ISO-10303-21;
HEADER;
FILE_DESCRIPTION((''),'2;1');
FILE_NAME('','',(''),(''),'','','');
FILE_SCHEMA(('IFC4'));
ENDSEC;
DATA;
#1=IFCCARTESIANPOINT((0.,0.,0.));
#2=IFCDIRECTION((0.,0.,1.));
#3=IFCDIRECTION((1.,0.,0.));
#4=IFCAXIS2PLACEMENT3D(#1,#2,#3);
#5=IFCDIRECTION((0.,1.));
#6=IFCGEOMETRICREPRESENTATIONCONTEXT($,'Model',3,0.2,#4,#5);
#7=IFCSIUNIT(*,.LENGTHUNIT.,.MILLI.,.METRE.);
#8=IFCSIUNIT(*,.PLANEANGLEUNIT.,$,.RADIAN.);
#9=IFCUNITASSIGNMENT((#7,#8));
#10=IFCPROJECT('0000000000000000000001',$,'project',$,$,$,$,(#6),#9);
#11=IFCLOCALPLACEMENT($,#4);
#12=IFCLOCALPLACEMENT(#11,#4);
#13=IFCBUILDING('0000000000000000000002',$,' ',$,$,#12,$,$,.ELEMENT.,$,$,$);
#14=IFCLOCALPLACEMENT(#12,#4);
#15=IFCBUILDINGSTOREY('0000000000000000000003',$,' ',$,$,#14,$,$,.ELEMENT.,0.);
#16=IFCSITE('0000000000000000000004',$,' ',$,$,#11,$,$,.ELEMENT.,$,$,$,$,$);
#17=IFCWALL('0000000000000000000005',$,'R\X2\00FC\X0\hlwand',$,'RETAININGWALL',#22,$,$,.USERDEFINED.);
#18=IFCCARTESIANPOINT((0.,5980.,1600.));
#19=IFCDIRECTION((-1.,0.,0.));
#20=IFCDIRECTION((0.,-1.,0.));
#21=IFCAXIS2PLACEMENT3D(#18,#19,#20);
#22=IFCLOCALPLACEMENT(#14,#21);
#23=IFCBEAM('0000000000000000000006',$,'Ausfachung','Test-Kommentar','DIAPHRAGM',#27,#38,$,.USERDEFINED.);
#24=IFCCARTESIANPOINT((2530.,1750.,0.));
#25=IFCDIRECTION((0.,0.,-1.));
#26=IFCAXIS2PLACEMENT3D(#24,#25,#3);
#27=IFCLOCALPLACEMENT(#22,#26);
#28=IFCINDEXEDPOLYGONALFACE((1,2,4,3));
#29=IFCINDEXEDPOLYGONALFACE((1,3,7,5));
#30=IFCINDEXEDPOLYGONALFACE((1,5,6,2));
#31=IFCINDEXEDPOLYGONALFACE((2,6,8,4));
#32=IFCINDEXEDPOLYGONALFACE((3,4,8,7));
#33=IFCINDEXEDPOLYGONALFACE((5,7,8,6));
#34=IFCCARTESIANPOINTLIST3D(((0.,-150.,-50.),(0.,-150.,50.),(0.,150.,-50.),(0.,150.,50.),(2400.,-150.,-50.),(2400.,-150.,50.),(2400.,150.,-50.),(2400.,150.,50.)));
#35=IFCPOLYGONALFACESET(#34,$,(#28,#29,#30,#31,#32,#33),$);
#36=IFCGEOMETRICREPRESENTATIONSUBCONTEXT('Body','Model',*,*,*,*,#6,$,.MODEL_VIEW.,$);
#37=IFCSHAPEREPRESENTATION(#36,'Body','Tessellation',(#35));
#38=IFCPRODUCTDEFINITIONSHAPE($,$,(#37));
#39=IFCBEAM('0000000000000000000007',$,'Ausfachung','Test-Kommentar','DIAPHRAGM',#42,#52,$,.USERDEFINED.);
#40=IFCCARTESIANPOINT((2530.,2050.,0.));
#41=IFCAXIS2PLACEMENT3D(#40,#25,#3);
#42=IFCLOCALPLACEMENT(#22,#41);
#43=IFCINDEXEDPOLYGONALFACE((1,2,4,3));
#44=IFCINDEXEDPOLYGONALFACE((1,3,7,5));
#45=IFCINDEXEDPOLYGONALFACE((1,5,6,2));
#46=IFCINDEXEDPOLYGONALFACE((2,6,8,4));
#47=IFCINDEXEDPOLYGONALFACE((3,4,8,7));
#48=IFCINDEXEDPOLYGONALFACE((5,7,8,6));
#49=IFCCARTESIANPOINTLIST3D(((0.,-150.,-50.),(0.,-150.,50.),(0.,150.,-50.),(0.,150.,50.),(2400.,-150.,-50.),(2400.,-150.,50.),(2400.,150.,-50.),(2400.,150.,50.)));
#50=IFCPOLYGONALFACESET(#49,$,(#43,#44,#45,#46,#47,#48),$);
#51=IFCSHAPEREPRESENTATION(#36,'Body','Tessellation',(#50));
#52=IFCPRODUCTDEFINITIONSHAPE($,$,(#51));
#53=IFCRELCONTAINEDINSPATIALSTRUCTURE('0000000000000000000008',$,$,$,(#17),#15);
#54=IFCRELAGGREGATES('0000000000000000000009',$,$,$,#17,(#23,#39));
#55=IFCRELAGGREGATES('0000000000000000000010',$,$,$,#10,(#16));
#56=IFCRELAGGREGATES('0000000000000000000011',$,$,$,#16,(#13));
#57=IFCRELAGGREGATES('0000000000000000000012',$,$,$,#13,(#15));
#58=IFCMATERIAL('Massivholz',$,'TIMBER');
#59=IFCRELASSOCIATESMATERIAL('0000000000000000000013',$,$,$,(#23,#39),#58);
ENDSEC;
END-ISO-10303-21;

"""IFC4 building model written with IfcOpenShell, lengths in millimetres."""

from ifc_helpers import new_model, si_unit, direction, frame, origin_with_axes, place, context, subcontext, project, spatial, line, indexed_curve, outline, extrude, material, element, aggregate, save


model = new_model("IFC4")

# Units and contexts
model_context = context("Model", 3, precision=0.2, world=origin_with_axes(), true_north=direction((0.0, 1.0)))
body_context = subcontext(model_context, "Body", "Model", "MODEL_VIEW")
ifc_project = project(units=[si_unit("LENGTHUNIT", "METRE", prefix="MILLI"), si_unit("PLANEANGLEUNIT", "RADIAN")], contexts=[model_context])

# Site, building, storey
site_placement = place(None, origin_with_axes())
site = spatial("IfcSite", under=ifc_project, at=site_placement, Name=" ", CompositionType="ELEMENT")
building_placement = place(site_placement, origin_with_axes())
building = spatial("IfcBuilding", under=site, at=building_placement, Name=" ", CompositionType="ELEMENT")
storey_placement = place(building_placement, origin_with_axes())
storey = spatial("IfcBuildingStorey", under=building, at=storey_placement, Name=" ", CompositionType="ELEMENT", Elevation=0.0)

# Wall, beams
wall_1_placement = place(storey_placement, frame((0.0, 5980.0, 1600.0), z_axis=(-1.0, 0.0, 0.0), x_axis=(0.0, -1.0, 0.0)))
wall_1 = element("IfcWall", 1, at=wall_1_placement, inside=storey, Name="Rühlwand", ObjectType="RETAININGWALL", PredefinedType="USERDEFINED")
ifc_material_1 = material(Name="Massivholz", Category="TIMBER")
beam_1_placement = place(wall_1_placement, frame((2530.0, 1750.0, 0.0), z_axis=(0.0, 0.0, -1.0), x_axis=(1.0, 0.0, 0.0)))
beam_1 = element("IfcBeam", 2, at=beam_1_placement, material=ifc_material_1, Name="Ausfachung", Description="Test-Kommentar", ObjectType="DIAPHRAGM", PredefinedType="USERDEFINED", context=body_context, shape_type="SolidModel", body=[
    extrude(outline(indexed_curve([(-50.0, -150.0), (50.0, -150.0), (50.0, 150.0), (-50.0, 150.0)], segments=[line(1, 2, 3, 4, 1)])), frame((0.0, 0.0, 0.0), z_axis=(-1.0, 0.0, 0.0), x_axis=(0.0, 0.0, 1.0)), (0.0, 0.0, -1.0), 2400.0),
])
beam_2_placement = place(wall_1_placement, frame((2530.0, 2050.0, 0.0), z_axis=(0.0, 0.0, -1.0), x_axis=(1.0, 0.0, 0.0)))
beam_2 = element("IfcBeam", 3, at=beam_2_placement, material=ifc_material_1, Name="Ausfachung", Description="Test-Kommentar", ObjectType="DIAPHRAGM", PredefinedType="USERDEFINED", context=body_context, shape_type="SolidModel", body=[
    extrude(outline(indexed_curve([(-50.0, -150.0), (50.0, -150.0), (50.0, 150.0), (-50.0, 150.0)], segments=[line(1, 2, 3, 4, 1)])), frame((0.0, 0.0, 0.0), z_axis=(-1.0, 0.0, 0.0), x_axis=(0.0, 0.0, 1.0)), (0.0, 0.0, -1.0), 2400.0),
])
aggregate(wall_1, [beam_1, beam_2])

save(model, "model.ifc")
